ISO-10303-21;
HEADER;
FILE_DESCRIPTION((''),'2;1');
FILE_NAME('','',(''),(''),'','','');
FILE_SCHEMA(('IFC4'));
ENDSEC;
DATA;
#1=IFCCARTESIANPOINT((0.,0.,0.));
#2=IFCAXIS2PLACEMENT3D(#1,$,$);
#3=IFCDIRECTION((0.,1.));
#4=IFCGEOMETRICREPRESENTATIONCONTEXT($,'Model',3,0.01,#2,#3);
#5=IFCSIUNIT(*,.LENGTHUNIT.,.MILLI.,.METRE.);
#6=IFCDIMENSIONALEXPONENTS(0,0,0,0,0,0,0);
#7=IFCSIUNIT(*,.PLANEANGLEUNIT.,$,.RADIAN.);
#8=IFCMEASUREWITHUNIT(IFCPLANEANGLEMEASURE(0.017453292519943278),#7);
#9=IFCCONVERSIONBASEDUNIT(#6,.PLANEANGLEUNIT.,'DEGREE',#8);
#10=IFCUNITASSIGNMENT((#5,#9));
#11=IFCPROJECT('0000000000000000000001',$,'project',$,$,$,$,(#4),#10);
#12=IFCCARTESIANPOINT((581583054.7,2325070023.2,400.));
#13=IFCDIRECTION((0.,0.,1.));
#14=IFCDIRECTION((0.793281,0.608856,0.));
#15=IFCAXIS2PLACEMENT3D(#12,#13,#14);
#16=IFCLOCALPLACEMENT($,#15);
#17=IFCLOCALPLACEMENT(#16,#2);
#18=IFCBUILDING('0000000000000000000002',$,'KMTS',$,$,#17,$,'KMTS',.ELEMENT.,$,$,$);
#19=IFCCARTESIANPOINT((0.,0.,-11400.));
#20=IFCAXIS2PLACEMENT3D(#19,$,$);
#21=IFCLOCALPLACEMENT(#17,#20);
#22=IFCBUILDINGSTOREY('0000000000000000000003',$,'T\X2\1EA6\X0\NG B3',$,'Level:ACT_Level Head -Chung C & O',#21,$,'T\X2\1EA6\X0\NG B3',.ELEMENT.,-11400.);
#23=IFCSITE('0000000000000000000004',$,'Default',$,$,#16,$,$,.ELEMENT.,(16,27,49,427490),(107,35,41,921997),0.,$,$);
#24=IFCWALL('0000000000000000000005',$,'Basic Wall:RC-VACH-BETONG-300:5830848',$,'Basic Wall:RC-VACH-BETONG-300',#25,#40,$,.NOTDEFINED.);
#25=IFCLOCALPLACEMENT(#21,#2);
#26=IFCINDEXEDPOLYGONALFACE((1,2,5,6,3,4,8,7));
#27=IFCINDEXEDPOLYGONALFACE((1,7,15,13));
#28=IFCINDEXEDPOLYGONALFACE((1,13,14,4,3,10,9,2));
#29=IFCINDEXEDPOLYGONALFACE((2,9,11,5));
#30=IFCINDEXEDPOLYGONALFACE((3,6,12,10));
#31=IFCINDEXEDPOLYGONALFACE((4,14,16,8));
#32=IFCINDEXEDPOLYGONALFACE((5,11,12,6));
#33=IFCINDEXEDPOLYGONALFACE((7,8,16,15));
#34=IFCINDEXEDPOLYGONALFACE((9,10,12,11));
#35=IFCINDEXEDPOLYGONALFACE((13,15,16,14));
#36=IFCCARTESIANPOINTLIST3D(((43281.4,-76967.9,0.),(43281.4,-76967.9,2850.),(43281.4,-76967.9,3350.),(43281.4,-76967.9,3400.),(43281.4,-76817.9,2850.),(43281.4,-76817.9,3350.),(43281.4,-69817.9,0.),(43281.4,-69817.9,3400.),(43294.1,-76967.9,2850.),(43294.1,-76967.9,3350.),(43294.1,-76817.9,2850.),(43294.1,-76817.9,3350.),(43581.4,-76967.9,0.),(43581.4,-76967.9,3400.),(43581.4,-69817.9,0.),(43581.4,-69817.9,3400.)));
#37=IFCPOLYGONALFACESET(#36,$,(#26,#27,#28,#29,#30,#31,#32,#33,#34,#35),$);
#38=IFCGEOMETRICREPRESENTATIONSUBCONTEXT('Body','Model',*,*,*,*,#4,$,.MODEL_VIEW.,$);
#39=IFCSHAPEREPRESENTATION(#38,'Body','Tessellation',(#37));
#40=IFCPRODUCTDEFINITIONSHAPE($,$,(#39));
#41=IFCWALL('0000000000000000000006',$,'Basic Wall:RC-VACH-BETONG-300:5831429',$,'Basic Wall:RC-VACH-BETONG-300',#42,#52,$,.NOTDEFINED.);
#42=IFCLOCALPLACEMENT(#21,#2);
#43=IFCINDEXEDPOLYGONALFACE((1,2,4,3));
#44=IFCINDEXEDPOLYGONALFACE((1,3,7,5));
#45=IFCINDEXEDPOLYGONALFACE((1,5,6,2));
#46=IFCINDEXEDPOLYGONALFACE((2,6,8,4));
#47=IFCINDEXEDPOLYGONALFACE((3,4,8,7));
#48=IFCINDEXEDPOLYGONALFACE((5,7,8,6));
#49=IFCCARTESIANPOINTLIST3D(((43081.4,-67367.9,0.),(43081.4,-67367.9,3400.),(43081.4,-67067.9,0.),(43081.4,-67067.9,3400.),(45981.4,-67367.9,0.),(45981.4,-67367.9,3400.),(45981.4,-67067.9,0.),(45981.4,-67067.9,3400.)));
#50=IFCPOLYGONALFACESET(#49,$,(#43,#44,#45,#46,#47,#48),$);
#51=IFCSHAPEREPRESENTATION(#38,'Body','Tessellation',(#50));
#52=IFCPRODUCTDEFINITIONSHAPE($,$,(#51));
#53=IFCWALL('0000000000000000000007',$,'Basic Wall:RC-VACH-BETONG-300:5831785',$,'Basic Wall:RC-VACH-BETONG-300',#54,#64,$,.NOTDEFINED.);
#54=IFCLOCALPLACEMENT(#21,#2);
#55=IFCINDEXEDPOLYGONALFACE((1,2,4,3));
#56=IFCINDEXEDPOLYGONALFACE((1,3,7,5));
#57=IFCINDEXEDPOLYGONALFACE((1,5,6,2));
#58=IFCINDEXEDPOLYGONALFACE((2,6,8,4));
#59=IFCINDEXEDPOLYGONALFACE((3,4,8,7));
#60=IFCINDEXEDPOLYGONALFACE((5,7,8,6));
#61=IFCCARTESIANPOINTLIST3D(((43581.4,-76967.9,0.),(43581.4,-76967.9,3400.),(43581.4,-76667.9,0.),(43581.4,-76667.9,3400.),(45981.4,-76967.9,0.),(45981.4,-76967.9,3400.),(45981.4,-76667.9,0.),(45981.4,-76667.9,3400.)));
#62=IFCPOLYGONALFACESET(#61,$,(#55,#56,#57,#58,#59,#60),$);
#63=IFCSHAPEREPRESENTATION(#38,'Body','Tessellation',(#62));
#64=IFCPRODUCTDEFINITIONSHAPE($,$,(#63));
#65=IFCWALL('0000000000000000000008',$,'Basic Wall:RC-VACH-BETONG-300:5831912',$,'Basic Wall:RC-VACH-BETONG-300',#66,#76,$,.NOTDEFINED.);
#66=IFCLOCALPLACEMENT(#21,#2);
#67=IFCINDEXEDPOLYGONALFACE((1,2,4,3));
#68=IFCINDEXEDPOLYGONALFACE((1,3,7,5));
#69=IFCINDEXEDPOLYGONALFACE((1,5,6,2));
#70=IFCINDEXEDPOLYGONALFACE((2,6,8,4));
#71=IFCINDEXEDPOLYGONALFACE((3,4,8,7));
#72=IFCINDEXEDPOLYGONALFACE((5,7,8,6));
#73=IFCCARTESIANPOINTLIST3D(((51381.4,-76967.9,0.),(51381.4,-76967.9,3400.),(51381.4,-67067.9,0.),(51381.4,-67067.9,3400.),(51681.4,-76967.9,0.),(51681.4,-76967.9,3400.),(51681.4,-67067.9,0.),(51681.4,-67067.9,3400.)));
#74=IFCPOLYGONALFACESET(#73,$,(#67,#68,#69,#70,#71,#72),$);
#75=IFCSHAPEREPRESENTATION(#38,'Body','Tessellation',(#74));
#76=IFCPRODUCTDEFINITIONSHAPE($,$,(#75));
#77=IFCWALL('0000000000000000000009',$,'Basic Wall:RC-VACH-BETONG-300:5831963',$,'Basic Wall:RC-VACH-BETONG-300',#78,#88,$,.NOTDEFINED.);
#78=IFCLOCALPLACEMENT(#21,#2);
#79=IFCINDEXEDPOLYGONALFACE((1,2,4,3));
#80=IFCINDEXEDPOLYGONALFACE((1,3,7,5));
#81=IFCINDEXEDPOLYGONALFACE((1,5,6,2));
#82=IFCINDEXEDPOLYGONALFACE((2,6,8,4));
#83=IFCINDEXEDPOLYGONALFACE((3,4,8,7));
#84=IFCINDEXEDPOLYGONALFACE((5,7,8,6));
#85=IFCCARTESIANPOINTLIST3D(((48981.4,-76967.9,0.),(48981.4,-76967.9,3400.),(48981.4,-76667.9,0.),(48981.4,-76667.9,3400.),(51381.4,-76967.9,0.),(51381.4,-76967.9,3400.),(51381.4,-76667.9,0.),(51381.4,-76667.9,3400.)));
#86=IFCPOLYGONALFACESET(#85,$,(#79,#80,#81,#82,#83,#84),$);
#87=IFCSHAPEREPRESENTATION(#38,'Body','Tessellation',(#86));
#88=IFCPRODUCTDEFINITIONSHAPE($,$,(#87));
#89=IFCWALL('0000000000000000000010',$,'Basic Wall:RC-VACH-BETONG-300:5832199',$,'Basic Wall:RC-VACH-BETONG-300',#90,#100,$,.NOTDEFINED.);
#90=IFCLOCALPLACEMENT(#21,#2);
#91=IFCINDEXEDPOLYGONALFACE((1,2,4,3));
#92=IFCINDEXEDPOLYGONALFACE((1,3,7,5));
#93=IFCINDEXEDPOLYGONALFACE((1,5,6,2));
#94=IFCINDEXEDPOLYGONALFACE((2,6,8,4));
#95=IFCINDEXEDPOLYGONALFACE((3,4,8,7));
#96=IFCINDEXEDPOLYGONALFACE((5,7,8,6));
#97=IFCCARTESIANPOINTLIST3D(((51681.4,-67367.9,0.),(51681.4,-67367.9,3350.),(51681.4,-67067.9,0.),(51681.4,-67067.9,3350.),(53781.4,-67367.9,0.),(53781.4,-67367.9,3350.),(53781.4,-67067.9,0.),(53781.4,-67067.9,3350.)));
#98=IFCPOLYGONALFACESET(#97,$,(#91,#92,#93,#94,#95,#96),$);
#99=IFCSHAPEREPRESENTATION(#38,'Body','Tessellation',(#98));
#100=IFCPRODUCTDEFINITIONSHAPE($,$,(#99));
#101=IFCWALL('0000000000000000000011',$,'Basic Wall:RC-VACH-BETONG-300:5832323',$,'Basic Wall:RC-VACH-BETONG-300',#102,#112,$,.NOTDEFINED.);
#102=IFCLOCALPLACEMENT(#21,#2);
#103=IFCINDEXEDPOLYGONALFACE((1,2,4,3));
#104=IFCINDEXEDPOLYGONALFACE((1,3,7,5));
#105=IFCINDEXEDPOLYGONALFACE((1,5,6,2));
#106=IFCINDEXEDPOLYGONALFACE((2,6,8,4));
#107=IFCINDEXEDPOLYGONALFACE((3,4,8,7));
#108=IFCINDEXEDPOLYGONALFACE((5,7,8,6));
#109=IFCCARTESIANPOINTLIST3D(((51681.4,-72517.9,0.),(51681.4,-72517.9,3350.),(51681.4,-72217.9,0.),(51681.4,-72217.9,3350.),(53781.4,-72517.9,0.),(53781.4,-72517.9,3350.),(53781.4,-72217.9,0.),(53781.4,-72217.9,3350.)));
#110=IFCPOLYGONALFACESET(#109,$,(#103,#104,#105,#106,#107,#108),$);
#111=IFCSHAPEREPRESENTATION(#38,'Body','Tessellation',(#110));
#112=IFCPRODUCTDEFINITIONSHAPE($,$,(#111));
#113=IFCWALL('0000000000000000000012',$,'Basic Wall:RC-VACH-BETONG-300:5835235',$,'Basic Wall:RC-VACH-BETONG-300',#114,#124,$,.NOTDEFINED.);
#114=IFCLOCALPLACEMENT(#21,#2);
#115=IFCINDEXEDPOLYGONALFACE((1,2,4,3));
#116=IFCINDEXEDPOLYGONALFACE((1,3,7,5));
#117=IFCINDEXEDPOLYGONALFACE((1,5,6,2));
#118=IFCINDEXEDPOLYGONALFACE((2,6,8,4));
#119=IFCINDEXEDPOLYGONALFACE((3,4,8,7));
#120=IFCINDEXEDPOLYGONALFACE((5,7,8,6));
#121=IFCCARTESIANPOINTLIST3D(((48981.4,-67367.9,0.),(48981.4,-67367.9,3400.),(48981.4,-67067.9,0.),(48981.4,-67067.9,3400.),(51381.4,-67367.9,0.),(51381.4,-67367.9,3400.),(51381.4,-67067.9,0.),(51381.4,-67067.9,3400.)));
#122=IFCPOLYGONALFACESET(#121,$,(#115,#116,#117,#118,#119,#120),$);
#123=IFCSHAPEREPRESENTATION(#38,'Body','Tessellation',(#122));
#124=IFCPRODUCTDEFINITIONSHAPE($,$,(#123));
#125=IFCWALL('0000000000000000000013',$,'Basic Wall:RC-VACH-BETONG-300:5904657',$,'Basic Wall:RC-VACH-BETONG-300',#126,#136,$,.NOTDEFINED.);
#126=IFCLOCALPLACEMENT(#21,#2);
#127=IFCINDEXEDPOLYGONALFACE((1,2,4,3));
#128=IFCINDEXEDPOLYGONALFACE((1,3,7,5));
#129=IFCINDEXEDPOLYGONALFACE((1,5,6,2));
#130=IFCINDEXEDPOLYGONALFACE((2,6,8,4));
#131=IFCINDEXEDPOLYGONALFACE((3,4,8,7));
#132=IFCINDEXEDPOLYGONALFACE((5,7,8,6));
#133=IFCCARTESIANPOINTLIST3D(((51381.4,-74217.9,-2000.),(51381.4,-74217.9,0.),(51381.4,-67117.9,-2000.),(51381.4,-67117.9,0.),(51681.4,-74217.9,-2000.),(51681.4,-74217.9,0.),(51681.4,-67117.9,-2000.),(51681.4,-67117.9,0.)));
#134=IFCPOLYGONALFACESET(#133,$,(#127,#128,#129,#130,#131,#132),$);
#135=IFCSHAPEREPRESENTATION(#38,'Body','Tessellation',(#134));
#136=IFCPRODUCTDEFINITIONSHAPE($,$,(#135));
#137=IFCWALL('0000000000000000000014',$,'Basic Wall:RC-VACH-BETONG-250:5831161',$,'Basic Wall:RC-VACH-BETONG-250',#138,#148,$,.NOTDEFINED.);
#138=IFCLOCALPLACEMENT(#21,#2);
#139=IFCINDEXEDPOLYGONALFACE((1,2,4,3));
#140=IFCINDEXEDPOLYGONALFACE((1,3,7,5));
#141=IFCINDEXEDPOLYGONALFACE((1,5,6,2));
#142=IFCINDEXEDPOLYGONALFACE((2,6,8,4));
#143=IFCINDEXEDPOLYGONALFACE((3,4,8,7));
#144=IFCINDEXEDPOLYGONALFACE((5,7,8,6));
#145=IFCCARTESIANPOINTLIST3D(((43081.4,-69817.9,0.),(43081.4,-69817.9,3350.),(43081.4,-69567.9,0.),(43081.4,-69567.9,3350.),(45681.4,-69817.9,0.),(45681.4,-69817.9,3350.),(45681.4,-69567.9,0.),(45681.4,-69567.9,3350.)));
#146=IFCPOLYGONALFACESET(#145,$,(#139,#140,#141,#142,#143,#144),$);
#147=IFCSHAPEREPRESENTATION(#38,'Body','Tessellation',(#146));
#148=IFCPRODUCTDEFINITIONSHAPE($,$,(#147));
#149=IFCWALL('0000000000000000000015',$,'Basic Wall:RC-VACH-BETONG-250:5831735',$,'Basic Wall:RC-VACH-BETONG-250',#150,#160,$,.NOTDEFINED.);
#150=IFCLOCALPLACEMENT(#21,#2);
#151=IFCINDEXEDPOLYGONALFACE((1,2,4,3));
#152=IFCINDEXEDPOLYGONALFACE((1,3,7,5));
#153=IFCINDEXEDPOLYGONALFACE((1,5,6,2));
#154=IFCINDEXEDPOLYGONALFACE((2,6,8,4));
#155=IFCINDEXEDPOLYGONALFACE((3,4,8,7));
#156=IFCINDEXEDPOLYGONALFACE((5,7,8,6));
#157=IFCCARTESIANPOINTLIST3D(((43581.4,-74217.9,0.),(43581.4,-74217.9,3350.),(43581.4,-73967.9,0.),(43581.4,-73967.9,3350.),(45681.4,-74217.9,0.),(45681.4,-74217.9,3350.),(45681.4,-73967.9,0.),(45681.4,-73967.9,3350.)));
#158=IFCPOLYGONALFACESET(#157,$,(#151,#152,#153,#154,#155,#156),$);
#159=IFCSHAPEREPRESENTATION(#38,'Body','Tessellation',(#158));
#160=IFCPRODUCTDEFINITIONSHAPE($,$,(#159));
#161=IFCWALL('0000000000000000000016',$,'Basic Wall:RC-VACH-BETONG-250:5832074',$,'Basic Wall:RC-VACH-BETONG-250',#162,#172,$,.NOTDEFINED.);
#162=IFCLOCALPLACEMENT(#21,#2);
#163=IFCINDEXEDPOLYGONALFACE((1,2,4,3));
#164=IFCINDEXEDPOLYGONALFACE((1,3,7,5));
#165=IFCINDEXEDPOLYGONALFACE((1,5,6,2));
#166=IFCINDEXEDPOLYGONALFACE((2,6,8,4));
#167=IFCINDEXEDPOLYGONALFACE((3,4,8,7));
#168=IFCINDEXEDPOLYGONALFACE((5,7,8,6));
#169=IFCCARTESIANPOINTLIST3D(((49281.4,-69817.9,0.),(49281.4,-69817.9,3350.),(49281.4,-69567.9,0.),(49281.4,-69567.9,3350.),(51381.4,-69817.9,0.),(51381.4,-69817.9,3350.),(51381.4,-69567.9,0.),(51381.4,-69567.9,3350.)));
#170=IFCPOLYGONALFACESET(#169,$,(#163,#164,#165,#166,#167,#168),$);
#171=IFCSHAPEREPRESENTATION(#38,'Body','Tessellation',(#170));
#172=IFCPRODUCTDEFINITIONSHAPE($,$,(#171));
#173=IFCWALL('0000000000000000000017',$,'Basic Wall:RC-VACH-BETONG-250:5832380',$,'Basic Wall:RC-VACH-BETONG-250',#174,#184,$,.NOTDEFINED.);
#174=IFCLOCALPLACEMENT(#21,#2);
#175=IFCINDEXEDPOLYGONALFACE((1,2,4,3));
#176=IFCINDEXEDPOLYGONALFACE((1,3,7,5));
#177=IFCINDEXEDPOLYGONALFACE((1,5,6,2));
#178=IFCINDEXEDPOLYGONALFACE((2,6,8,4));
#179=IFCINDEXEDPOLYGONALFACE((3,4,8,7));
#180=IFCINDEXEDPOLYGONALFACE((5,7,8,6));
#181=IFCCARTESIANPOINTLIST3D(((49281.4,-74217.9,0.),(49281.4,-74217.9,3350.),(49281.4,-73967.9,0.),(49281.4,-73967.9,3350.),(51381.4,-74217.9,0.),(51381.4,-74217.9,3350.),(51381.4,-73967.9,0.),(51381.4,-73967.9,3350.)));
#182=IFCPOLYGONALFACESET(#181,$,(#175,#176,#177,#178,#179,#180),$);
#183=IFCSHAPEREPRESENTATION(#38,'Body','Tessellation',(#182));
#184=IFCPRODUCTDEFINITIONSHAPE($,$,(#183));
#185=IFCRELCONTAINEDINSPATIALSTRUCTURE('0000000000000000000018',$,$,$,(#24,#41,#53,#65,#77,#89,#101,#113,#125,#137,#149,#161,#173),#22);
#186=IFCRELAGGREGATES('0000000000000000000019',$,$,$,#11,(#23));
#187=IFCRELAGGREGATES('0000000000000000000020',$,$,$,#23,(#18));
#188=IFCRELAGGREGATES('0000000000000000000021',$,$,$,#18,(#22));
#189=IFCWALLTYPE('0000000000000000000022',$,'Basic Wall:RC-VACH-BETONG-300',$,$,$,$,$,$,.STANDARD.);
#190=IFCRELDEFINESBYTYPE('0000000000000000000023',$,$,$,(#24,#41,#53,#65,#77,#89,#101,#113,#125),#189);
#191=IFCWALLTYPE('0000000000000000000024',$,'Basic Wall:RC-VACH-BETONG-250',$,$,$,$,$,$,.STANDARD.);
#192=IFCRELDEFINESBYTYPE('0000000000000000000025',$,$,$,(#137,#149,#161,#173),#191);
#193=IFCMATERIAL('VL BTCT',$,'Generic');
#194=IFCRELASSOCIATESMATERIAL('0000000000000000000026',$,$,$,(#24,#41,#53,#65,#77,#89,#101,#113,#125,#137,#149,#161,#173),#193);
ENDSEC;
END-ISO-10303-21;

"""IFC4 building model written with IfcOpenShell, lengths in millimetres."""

from ifc_helpers import new_model, entity, si_unit, converted_unit, direction, frame, origin, place, context, subcontext, project, spatial, indexed_curve, outline, extrude, material, type_object, element, save


model = new_model("IFC4")

# Units and contexts
model_context = context("Model", 3, precision=0.01, world=origin(), true_north=direction((0.0, 1.0)))
body_context = subcontext(model_context, "Body", "Model", "MODEL_VIEW")
ifc_project = project(units=[si_unit("LENGTHUNIT", "METRE", prefix="MILLI"), converted_unit("PLANEANGLEUNIT", "DEGREE", entity("IfcPlaneAngleMeasure", 0.017453292519943278), si_unit("PLANEANGLEUNIT", "RADIAN"), dimensions=[0, 0, 0, 0, 0, 0, 0])], contexts=[model_context])

# Site, building, storey
site_placement = place(None, frame((581583054.7, 2325070023.2, 400.0), z_axis=(0.0, 0.0, 1.0), x_axis=(0.793281, 0.608856, 0.0)))
site = spatial("IfcSite", under=ifc_project, at=site_placement, Name="Default", CompositionType="ELEMENT", RefLatitude=(16, 27, 49, 427490), RefLongitude=(107, 35, 41, 921997), RefElevation=0.0)
building_placement = place(site_placement, origin())
building = spatial("IfcBuilding", under=site, at=building_placement, Name="KMTS", LongName="KMTS", CompositionType="ELEMENT")
storey_placement = place(building_placement, frame((0.0, 0.0, -11400.0)))
storey = spatial("IfcBuildingStorey", under=building, at=storey_placement, Name="TẦNG B3", ObjectType="Level:ACT_Level Head -Chung C & O", LongName="TẦNG B3", CompositionType="ELEMENT", Elevation=-11400.0)

# Shared definitions
ifc_material = material(Name="VL BTCT", Category="Generic")

# Wall, opening
wall_type_1 = type_object("IfcWallType", Name="Basic Wall:RC-VACH-BETONG-300", PredefinedType="STANDARD")
wall_1_placement = place(storey_placement, frame((43431.4, -69817.9, 0.0), z_axis=(0.0, 0.0, 1.0), x_axis=(0.0, -1.0, 0.0)))
wall_1 = element("IfcWall", 1, at=wall_1_placement, inside=storey, type_object=wall_type_1, material=ifc_material, Name="Basic Wall:RC-VACH-BETONG-300:5830848", ObjectType="Basic Wall:RC-VACH-BETONG-300", PredefinedType="NOTDEFINED", context=body_context, shape_type="SweptSolid", body=[
    extrude(outline(indexed_curve([(7150.0, 150.0), (0.0, 150.0), (0.0, -150.0), (7150.0, -150.0), (7150.0, 150.0)], self_intersect=False)), origin(), (0.0, 0.0, 1.0), 3400.0),
])
opening_placement = place(storey_placement, frame((43431.4, -69817.9, 0.0), z_axis=(0.0, 0.0, 1.0), x_axis=(0.0, -1.0, 0.0)))
element("IfcOpeningElement", 2, at=opening_placement, cuts=wall_1, PredefinedType="OPENING", context=body_context, shape_type="SweptSolid", body=[
    extrude(outline(indexed_curve([(-75.0, -6.4), (75.0, -6.4), (75.0, 6.4), (-75.0, 6.4), (-75.0, -6.4)], self_intersect=False)), frame((7075.0, -143.6, 2850.0), z_axis=(0.0, 0.0, 1.0), x_axis=(-1.0, 0.0, 0.0)), (0.0, 0.0, 1.0), 500.0),
])

# Walls
wall_2_placement = place(storey_placement, frame((45981.4, -67217.9, 0.0), z_axis=(0.0, 0.0, 1.0), x_axis=(-1.0, 0.0, 0.0)))
element("IfcWall", 3, at=wall_2_placement, inside=storey, type_object=wall_type_1, material=ifc_material, Name="Basic Wall:RC-VACH-BETONG-300:5831429", ObjectType="Basic Wall:RC-VACH-BETONG-300", PredefinedType="NOTDEFINED", context=body_context, shape_type="SweptSolid", body=[
    extrude(outline(indexed_curve([(2900.0, 150.0), (0.0, 150.0), (0.0, -150.0), (2900.0, -150.0), (2900.0, 150.0)], self_intersect=False)), origin(), (0.0, 0.0, 1.0), 3400.0),
])
wall_3_placement = place(storey_placement, frame((45981.4, -76817.9, 0.0), z_axis=(0.0, 0.0, 1.0), x_axis=(-1.0, 0.0, 0.0)))
element("IfcWall", 4, at=wall_3_placement, inside=storey, type_object=wall_type_1, material=ifc_material, Name="Basic Wall:RC-VACH-BETONG-300:5831785", ObjectType="Basic Wall:RC-VACH-BETONG-300", PredefinedType="NOTDEFINED", context=body_context, shape_type="SweptSolid", body=[
    extrude(outline(indexed_curve([(2400.0, 150.0), (0.0, 150.0), (0.0, -150.0), (2400.0, -150.0), (2400.0, 150.0)], self_intersect=False)), origin(), (0.0, 0.0, 1.0), 3400.0),
])
wall_4_placement = place(storey_placement, frame((51531.4, -67067.9, 0.0), z_axis=(0.0, 0.0, 1.0), x_axis=(0.0, -1.0, 0.0)))
element("IfcWall", 5, at=wall_4_placement, inside=storey, type_object=wall_type_1, material=ifc_material, Name="Basic Wall:RC-VACH-BETONG-300:5831912", ObjectType="Basic Wall:RC-VACH-BETONG-300", PredefinedType="NOTDEFINED", context=body_context, shape_type="SweptSolid", body=[
    extrude(outline(indexed_curve([(9900.0, 150.0), (0.0, 150.0), (0.0, -150.0), (9900.0, -150.0), (9900.0, 150.0)], self_intersect=False)), origin(), (0.0, 0.0, 1.0), 3400.0),
])
wall_5_placement = place(storey_placement, frame((51381.4, -76817.9, 0.0), z_axis=(0.0, 0.0, 1.0), x_axis=(-1.0, 0.0, 0.0)))
element("IfcWall", 6, at=wall_5_placement, inside=storey, type_object=wall_type_1, material=ifc_material, Name="Basic Wall:RC-VACH-BETONG-300:5831963", ObjectType="Basic Wall:RC-VACH-BETONG-300", PredefinedType="NOTDEFINED", context=body_context, shape_type="SweptSolid", body=[
    extrude(outline(indexed_curve([(2400.0, 150.0), (0.0, 150.0), (0.0, -150.0), (2400.0, -150.0), (2400.0, 150.0)], self_intersect=False)), origin(), (0.0, 0.0, 1.0), 3400.0),
])
wall_6_placement = place(storey_placement, frame((53781.4, -67217.9, 0.0), z_axis=(0.0, 0.0, 1.0), x_axis=(-1.0, 0.0, 0.0)))
element("IfcWall", 7, at=wall_6_placement, inside=storey, type_object=wall_type_1, material=ifc_material, Name="Basic Wall:RC-VACH-BETONG-300:5832199", ObjectType="Basic Wall:RC-VACH-BETONG-300", PredefinedType="NOTDEFINED", context=body_context, shape_type="SweptSolid", body=[
    extrude(outline(indexed_curve([(2100.0, 150.0), (0.0, 150.0), (0.0, -150.0), (2100.0, -150.0), (2100.0, 150.0)], self_intersect=False)), origin(), (0.0, 0.0, 1.0), 3350.0),
])
wall_7_placement = place(storey_placement, frame((53781.4, -72367.9, 0.0), z_axis=(0.0, 0.0, 1.0), x_axis=(-1.0, 0.0, 0.0)))
element("IfcWall", 8, at=wall_7_placement, inside=storey, type_object=wall_type_1, material=ifc_material, Name="Basic Wall:RC-VACH-BETONG-300:5832323", ObjectType="Basic Wall:RC-VACH-BETONG-300", PredefinedType="NOTDEFINED", context=body_context, shape_type="SweptSolid", body=[
    extrude(outline(indexed_curve([(2100.0, 150.0), (0.0, 150.0), (0.0, -150.0), (2100.0, -150.0), (2100.0, 150.0)], self_intersect=False)), origin(), (0.0, 0.0, 1.0), 3350.0),
])
wall_8_placement = place(storey_placement, frame((51381.4, -67217.9, 0.0), z_axis=(0.0, 0.0, 1.0), x_axis=(-1.0, 0.0, 0.0)))
element("IfcWall", 9, at=wall_8_placement, inside=storey, type_object=wall_type_1, material=ifc_material, Name="Basic Wall:RC-VACH-BETONG-300:5835235", ObjectType="Basic Wall:RC-VACH-BETONG-300", PredefinedType="NOTDEFINED", context=body_context, shape_type="SweptSolid", body=[
    extrude(outline(indexed_curve([(2400.0, 150.0), (0.0, 150.0), (0.0, -150.0), (2400.0, -150.0), (2400.0, 150.0)], self_intersect=False)), origin(), (0.0, 0.0, 1.0), 3400.0),
])
wall_9_placement = place(storey_placement, frame((51531.4, -67117.9, -2000.0), z_axis=(0.0, 0.0, 1.0), x_axis=(0.0, -1.0, 0.0)))
element("IfcWall", 10, at=wall_9_placement, inside=storey, type_object=wall_type_1, material=ifc_material, Name="Basic Wall:RC-VACH-BETONG-300:5904657", ObjectType="Basic Wall:RC-VACH-BETONG-300", PredefinedType="NOTDEFINED", context=body_context, shape_type="SweptSolid", body=[
    extrude(outline(indexed_curve([(7100.0, 150.0), (0.0, 150.0), (0.0, -150.0), (7100.0, -150.0), (7100.0, 150.0)], self_intersect=False)), origin(), (0.0, 0.0, 1.0), 2000.0),
])
wall_type_2 = type_object("IfcWallType", Name="Basic Wall:RC-VACH-BETONG-250", PredefinedType="STANDARD")
wall_10_placement = place(storey_placement, frame((45681.4, -69692.9, 0.0), z_axis=(0.0, 0.0, 1.0), x_axis=(-1.0, 0.0, 0.0)))
element("IfcWall", 11, at=wall_10_placement, inside=storey, type_object=wall_type_2, material=ifc_material, Name="Basic Wall:RC-VACH-BETONG-250:5831161", ObjectType="Basic Wall:RC-VACH-BETONG-250", PredefinedType="NOTDEFINED", context=body_context, shape_type="SweptSolid", body=[
    extrude(outline(indexed_curve([(2600.0, 125.0), (0.0, 125.0), (0.0, -125.0), (2600.0, -125.0), (2600.0, 125.0)], self_intersect=False)), origin(), (0.0, 0.0, 1.0), 3350.0),
])
wall_11_placement = place(storey_placement, frame((45681.4, -74092.9, 0.0), z_axis=(0.0, 0.0, 1.0), x_axis=(-1.0, 0.0, 0.0)))
element("IfcWall", 12, at=wall_11_placement, inside=storey, type_object=wall_type_2, material=ifc_material, Name="Basic Wall:RC-VACH-BETONG-250:5831735", ObjectType="Basic Wall:RC-VACH-BETONG-250", PredefinedType="NOTDEFINED", context=body_context, shape_type="SweptSolid", body=[
    extrude(outline(indexed_curve([(2100.0, 125.0), (0.0, 125.0), (0.0, -125.0), (2100.0, -125.0), (2100.0, 125.0)], self_intersect=False)), origin(), (0.0, 0.0, 1.0), 3350.0),
])
for number, where, z_axis, x_axis, name in (
    (13, (51381.4, -69692.9, 0.0), (0.0, 0.0, 1.0), (-1.0, 0.0, 0.0), "Basic Wall:RC-VACH-BETONG-250:5832074"),
    (14, (51381.4, -74092.9, 0.0), (0.0, 0.0, 1.0), (-1.0, 0.0, 0.0), "Basic Wall:RC-VACH-BETONG-250:5832380"),
):
    element("IfcWall", number, at=place(storey_placement, frame(where, z_axis=z_axis, x_axis=x_axis)), inside=storey, type_object=wall_type_2, material=ifc_material, Name=name, ObjectType="Basic Wall:RC-VACH-BETONG-250", PredefinedType="NOTDEFINED", context=body_context, shape_type="SweptSolid", body=[
        extrude(outline(indexed_curve([(2100.0, 125.0), (0.0, 125.0), (0.0, -125.0), (2100.0, -125.0), (2100.0, 125.0)], self_intersect=False)), origin(), (0.0, 0.0, 1.0), 3350.0),
    ])

save(model, "model.ifc")
